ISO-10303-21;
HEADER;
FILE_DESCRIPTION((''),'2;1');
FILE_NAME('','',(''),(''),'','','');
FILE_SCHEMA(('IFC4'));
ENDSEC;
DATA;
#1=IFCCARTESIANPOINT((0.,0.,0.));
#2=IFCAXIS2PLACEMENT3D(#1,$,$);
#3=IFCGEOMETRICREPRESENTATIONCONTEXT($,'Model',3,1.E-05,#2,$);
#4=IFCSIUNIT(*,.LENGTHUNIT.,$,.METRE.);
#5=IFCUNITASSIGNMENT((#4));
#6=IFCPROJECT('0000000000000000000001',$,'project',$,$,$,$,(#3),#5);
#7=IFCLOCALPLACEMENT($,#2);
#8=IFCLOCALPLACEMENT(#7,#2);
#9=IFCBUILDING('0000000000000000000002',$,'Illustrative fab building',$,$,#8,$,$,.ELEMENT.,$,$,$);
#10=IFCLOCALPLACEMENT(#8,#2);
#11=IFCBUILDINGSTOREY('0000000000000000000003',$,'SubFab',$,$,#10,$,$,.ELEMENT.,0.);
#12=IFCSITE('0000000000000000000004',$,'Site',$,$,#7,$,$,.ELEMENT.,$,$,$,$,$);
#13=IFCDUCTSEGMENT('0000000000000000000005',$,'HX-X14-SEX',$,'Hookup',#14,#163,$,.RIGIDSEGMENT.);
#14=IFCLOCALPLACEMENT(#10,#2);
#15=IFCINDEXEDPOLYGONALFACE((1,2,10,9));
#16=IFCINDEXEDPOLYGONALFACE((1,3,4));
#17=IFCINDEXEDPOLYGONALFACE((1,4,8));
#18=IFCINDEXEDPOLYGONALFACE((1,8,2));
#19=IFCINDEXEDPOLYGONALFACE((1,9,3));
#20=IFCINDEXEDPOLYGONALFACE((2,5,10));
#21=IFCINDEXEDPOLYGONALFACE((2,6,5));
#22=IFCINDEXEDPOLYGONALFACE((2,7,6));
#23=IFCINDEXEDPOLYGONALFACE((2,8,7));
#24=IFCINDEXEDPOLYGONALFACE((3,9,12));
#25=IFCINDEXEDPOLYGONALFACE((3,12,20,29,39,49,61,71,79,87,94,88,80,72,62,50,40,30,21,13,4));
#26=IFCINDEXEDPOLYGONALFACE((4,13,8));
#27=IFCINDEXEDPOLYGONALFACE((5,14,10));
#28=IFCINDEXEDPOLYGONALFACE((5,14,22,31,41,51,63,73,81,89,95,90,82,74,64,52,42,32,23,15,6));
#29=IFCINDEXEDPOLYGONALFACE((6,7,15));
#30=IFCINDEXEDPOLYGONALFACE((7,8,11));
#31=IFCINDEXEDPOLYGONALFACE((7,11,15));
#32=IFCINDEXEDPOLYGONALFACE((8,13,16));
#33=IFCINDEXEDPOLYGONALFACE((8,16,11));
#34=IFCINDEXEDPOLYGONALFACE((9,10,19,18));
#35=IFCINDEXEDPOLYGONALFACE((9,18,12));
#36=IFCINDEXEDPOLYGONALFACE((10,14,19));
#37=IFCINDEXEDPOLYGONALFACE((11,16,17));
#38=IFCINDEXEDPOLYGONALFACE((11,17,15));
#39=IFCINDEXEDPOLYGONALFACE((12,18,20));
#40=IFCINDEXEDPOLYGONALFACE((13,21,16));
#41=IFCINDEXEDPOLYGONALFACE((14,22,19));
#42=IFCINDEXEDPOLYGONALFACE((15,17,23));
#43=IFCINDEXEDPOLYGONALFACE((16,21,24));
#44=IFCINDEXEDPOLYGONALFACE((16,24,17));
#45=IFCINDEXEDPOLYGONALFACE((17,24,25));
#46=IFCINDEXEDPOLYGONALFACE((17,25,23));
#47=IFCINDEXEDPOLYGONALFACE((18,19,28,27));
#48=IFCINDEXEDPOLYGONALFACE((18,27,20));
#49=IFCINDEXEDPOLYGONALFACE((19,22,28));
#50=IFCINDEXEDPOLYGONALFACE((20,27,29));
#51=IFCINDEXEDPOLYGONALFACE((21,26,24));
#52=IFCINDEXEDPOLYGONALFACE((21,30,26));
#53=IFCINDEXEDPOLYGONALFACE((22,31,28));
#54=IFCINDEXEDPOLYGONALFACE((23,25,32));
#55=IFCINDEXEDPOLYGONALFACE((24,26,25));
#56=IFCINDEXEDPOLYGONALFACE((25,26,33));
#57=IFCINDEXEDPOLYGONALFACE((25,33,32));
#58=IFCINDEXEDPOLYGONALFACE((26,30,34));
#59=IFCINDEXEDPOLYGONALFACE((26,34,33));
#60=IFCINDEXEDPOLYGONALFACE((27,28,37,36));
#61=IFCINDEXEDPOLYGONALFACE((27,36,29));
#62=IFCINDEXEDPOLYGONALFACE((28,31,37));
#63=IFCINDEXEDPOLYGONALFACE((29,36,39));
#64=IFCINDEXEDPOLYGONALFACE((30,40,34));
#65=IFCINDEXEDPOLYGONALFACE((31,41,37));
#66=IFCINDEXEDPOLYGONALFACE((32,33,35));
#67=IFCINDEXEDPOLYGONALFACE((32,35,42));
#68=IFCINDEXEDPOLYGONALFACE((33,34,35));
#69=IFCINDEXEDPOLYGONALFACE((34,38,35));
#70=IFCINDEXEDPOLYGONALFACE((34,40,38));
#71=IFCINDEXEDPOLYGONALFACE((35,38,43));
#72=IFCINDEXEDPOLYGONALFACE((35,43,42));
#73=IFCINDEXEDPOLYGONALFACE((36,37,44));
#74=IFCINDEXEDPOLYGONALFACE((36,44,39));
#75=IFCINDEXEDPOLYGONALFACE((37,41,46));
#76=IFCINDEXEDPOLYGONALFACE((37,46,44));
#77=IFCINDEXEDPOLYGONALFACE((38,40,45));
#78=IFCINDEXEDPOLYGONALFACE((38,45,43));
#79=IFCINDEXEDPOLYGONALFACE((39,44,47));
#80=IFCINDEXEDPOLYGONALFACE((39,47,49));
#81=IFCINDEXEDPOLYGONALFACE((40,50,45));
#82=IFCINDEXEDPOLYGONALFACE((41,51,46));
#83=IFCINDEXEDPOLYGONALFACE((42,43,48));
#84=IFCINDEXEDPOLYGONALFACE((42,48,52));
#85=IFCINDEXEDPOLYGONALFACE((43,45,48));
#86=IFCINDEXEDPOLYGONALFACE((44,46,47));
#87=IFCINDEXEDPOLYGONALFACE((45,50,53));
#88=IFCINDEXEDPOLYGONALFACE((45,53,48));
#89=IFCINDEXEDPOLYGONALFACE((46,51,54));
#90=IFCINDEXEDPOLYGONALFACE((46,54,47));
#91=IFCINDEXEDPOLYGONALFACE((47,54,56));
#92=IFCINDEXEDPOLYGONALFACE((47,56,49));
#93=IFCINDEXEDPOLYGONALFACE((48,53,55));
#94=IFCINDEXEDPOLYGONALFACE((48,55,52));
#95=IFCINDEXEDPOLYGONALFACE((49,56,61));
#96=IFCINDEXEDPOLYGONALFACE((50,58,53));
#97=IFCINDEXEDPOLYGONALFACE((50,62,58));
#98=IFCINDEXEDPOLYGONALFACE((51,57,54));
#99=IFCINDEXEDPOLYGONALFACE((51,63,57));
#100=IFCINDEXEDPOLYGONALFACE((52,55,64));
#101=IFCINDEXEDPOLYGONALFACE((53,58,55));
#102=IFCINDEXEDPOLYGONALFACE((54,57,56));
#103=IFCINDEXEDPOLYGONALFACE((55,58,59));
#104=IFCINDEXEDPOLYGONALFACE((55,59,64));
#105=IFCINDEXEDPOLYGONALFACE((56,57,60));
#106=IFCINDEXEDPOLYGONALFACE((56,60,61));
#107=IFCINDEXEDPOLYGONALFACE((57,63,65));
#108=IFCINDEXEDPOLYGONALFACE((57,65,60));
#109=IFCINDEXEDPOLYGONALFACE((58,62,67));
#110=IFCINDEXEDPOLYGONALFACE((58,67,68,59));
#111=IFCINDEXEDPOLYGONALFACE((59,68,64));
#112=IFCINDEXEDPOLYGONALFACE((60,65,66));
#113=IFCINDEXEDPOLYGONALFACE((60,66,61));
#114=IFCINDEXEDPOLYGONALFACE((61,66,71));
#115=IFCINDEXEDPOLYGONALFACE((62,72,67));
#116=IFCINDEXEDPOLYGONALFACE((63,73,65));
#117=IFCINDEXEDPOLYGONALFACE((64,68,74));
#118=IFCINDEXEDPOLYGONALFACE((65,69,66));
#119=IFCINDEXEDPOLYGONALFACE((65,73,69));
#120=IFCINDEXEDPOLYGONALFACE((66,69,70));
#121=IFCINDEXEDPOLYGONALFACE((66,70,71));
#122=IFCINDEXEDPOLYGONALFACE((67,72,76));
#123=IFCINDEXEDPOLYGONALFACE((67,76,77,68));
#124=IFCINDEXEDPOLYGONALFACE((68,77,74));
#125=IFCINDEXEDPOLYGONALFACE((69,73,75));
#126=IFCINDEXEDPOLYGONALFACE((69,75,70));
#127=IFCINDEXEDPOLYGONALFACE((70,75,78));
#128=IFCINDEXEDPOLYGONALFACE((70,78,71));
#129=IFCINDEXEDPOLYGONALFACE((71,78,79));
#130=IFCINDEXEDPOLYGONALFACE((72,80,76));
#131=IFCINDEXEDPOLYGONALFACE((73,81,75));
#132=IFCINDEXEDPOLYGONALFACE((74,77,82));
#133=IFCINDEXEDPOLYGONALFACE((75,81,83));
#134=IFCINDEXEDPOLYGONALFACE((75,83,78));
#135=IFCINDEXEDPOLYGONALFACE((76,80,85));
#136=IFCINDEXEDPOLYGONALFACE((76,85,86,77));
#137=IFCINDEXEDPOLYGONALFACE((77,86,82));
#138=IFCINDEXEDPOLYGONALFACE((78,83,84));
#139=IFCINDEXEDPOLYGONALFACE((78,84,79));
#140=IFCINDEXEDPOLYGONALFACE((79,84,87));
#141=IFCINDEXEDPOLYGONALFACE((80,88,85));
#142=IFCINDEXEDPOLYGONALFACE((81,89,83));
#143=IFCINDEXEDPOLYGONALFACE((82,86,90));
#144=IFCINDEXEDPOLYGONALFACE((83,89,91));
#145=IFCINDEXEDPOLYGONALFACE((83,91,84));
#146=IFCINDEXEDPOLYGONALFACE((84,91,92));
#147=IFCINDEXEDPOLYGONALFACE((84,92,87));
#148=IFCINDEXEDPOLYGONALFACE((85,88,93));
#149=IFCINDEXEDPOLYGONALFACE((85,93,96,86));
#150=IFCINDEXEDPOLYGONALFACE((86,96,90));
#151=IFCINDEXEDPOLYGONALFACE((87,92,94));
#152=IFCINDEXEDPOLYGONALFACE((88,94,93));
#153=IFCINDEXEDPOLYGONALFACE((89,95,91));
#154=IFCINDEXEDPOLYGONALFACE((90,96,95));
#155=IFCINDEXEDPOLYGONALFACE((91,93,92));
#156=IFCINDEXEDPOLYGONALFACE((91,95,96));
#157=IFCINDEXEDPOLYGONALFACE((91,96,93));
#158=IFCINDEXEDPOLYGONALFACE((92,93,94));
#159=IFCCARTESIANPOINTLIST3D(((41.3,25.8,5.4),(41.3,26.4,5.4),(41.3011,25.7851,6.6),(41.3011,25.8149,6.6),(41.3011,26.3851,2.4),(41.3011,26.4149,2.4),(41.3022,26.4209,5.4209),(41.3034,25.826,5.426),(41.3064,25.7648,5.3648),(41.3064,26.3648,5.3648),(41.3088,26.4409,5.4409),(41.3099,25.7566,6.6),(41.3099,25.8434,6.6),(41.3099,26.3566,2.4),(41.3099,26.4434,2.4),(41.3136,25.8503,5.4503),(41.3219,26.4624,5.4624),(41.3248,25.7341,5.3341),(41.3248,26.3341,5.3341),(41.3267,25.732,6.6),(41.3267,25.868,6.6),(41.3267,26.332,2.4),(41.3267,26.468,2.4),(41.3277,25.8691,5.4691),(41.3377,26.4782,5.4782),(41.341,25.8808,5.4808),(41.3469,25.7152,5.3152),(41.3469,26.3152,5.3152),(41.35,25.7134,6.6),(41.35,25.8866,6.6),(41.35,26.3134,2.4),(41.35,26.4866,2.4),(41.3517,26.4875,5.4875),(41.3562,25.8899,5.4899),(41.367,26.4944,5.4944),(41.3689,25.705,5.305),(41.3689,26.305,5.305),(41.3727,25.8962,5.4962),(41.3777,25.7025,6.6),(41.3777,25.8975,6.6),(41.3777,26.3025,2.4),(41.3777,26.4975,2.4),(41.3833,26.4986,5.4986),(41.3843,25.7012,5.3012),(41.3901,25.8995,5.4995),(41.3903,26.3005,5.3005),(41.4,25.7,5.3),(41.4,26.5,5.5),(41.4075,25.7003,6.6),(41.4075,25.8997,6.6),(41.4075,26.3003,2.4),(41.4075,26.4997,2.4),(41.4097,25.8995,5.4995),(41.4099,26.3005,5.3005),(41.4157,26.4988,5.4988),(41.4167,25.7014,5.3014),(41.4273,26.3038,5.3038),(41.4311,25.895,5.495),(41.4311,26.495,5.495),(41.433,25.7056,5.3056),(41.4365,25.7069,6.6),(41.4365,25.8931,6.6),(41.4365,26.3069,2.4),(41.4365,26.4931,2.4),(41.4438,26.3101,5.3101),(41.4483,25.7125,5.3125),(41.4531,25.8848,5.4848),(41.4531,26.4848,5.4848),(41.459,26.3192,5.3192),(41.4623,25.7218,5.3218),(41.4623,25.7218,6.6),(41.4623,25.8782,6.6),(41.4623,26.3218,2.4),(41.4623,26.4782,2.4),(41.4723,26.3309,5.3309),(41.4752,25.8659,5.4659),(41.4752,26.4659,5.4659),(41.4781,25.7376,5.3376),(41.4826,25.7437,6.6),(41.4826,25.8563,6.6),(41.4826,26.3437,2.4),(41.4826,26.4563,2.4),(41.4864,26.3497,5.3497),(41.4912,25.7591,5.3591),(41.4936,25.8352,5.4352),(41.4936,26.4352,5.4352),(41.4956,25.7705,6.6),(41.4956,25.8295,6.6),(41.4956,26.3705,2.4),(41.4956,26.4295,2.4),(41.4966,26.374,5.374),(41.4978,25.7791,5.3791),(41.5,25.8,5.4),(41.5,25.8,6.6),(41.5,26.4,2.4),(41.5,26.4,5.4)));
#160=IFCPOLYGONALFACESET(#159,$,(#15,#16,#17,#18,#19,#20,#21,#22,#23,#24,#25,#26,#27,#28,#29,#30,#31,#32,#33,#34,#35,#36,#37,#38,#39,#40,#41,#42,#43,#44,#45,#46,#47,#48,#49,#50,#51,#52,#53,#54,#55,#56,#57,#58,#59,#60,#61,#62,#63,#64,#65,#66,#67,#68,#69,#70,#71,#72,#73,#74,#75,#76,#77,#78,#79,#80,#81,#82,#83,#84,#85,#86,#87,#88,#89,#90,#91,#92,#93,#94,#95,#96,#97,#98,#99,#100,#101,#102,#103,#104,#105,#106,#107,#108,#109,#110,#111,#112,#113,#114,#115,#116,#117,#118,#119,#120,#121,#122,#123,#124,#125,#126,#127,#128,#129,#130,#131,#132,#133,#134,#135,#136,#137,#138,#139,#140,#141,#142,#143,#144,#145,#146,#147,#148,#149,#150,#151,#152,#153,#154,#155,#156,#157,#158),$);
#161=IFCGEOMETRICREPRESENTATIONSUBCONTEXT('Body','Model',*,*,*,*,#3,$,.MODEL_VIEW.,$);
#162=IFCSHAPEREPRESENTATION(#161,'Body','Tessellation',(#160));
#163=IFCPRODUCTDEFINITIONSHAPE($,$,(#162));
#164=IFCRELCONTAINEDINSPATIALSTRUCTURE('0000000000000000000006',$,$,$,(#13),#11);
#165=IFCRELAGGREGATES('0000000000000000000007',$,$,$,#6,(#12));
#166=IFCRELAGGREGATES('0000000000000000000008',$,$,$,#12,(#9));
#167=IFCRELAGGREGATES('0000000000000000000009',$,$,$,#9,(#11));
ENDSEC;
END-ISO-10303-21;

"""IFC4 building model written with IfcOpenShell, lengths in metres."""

from ifc_helpers import new_model, entity, si_unit, origin, place, context, subcontext, project, spatial, element, save


model = new_model("IFC4")

# Units and contexts
model_context = context("Model", 3, precision=1e-05, world=origin())
body_context = subcontext(model_context, "Body", "Model", "MODEL_VIEW")
ifc_project = project(units=[si_unit("LENGTHUNIT", "METRE")], contexts=[model_context])

# Site, building, storey
site_placement = place(None, origin())
site = spatial("IfcSite", under=ifc_project, at=site_placement, Name="Site", CompositionType="ELEMENT")
building_placement = place(site_placement, origin())
building = spatial("IfcBuilding", under=site, at=building_placement, Name="Illustrative fab building", CompositionType="ELEMENT")
storey_placement = place(building_placement, origin())
storey = spatial("IfcBuildingStorey", under=building, at=storey_placement, Name="SubFab", CompositionType="ELEMENT", Elevation=0.0)

# Duct segment
duct_segment_1_placement = place(storey_placement, origin())
element("IfcDuctSegment", 1, at=duct_segment_1_placement, inside=storey, Name="HX-X14-SEX", ObjectType="Hookup", PredefinedType="RIGIDSEGMENT", context=body_context, shape_type="AdvancedSweptSolid", body=[
    entity("IfcSweptDiskSolid", entity("IfcPolyline", [entity("IfcCartesianPoint", [41.4, 26.4, 2.4]), entity("IfcCartesianPoint", [41.4, 26.4, 5.4]), entity("IfcCartesianPoint", [41.4, 25.8, 5.4]), entity("IfcCartesianPoint", [41.4, 25.8, 6.6])]), 0.1),
])

save(model, "model.ifc")
